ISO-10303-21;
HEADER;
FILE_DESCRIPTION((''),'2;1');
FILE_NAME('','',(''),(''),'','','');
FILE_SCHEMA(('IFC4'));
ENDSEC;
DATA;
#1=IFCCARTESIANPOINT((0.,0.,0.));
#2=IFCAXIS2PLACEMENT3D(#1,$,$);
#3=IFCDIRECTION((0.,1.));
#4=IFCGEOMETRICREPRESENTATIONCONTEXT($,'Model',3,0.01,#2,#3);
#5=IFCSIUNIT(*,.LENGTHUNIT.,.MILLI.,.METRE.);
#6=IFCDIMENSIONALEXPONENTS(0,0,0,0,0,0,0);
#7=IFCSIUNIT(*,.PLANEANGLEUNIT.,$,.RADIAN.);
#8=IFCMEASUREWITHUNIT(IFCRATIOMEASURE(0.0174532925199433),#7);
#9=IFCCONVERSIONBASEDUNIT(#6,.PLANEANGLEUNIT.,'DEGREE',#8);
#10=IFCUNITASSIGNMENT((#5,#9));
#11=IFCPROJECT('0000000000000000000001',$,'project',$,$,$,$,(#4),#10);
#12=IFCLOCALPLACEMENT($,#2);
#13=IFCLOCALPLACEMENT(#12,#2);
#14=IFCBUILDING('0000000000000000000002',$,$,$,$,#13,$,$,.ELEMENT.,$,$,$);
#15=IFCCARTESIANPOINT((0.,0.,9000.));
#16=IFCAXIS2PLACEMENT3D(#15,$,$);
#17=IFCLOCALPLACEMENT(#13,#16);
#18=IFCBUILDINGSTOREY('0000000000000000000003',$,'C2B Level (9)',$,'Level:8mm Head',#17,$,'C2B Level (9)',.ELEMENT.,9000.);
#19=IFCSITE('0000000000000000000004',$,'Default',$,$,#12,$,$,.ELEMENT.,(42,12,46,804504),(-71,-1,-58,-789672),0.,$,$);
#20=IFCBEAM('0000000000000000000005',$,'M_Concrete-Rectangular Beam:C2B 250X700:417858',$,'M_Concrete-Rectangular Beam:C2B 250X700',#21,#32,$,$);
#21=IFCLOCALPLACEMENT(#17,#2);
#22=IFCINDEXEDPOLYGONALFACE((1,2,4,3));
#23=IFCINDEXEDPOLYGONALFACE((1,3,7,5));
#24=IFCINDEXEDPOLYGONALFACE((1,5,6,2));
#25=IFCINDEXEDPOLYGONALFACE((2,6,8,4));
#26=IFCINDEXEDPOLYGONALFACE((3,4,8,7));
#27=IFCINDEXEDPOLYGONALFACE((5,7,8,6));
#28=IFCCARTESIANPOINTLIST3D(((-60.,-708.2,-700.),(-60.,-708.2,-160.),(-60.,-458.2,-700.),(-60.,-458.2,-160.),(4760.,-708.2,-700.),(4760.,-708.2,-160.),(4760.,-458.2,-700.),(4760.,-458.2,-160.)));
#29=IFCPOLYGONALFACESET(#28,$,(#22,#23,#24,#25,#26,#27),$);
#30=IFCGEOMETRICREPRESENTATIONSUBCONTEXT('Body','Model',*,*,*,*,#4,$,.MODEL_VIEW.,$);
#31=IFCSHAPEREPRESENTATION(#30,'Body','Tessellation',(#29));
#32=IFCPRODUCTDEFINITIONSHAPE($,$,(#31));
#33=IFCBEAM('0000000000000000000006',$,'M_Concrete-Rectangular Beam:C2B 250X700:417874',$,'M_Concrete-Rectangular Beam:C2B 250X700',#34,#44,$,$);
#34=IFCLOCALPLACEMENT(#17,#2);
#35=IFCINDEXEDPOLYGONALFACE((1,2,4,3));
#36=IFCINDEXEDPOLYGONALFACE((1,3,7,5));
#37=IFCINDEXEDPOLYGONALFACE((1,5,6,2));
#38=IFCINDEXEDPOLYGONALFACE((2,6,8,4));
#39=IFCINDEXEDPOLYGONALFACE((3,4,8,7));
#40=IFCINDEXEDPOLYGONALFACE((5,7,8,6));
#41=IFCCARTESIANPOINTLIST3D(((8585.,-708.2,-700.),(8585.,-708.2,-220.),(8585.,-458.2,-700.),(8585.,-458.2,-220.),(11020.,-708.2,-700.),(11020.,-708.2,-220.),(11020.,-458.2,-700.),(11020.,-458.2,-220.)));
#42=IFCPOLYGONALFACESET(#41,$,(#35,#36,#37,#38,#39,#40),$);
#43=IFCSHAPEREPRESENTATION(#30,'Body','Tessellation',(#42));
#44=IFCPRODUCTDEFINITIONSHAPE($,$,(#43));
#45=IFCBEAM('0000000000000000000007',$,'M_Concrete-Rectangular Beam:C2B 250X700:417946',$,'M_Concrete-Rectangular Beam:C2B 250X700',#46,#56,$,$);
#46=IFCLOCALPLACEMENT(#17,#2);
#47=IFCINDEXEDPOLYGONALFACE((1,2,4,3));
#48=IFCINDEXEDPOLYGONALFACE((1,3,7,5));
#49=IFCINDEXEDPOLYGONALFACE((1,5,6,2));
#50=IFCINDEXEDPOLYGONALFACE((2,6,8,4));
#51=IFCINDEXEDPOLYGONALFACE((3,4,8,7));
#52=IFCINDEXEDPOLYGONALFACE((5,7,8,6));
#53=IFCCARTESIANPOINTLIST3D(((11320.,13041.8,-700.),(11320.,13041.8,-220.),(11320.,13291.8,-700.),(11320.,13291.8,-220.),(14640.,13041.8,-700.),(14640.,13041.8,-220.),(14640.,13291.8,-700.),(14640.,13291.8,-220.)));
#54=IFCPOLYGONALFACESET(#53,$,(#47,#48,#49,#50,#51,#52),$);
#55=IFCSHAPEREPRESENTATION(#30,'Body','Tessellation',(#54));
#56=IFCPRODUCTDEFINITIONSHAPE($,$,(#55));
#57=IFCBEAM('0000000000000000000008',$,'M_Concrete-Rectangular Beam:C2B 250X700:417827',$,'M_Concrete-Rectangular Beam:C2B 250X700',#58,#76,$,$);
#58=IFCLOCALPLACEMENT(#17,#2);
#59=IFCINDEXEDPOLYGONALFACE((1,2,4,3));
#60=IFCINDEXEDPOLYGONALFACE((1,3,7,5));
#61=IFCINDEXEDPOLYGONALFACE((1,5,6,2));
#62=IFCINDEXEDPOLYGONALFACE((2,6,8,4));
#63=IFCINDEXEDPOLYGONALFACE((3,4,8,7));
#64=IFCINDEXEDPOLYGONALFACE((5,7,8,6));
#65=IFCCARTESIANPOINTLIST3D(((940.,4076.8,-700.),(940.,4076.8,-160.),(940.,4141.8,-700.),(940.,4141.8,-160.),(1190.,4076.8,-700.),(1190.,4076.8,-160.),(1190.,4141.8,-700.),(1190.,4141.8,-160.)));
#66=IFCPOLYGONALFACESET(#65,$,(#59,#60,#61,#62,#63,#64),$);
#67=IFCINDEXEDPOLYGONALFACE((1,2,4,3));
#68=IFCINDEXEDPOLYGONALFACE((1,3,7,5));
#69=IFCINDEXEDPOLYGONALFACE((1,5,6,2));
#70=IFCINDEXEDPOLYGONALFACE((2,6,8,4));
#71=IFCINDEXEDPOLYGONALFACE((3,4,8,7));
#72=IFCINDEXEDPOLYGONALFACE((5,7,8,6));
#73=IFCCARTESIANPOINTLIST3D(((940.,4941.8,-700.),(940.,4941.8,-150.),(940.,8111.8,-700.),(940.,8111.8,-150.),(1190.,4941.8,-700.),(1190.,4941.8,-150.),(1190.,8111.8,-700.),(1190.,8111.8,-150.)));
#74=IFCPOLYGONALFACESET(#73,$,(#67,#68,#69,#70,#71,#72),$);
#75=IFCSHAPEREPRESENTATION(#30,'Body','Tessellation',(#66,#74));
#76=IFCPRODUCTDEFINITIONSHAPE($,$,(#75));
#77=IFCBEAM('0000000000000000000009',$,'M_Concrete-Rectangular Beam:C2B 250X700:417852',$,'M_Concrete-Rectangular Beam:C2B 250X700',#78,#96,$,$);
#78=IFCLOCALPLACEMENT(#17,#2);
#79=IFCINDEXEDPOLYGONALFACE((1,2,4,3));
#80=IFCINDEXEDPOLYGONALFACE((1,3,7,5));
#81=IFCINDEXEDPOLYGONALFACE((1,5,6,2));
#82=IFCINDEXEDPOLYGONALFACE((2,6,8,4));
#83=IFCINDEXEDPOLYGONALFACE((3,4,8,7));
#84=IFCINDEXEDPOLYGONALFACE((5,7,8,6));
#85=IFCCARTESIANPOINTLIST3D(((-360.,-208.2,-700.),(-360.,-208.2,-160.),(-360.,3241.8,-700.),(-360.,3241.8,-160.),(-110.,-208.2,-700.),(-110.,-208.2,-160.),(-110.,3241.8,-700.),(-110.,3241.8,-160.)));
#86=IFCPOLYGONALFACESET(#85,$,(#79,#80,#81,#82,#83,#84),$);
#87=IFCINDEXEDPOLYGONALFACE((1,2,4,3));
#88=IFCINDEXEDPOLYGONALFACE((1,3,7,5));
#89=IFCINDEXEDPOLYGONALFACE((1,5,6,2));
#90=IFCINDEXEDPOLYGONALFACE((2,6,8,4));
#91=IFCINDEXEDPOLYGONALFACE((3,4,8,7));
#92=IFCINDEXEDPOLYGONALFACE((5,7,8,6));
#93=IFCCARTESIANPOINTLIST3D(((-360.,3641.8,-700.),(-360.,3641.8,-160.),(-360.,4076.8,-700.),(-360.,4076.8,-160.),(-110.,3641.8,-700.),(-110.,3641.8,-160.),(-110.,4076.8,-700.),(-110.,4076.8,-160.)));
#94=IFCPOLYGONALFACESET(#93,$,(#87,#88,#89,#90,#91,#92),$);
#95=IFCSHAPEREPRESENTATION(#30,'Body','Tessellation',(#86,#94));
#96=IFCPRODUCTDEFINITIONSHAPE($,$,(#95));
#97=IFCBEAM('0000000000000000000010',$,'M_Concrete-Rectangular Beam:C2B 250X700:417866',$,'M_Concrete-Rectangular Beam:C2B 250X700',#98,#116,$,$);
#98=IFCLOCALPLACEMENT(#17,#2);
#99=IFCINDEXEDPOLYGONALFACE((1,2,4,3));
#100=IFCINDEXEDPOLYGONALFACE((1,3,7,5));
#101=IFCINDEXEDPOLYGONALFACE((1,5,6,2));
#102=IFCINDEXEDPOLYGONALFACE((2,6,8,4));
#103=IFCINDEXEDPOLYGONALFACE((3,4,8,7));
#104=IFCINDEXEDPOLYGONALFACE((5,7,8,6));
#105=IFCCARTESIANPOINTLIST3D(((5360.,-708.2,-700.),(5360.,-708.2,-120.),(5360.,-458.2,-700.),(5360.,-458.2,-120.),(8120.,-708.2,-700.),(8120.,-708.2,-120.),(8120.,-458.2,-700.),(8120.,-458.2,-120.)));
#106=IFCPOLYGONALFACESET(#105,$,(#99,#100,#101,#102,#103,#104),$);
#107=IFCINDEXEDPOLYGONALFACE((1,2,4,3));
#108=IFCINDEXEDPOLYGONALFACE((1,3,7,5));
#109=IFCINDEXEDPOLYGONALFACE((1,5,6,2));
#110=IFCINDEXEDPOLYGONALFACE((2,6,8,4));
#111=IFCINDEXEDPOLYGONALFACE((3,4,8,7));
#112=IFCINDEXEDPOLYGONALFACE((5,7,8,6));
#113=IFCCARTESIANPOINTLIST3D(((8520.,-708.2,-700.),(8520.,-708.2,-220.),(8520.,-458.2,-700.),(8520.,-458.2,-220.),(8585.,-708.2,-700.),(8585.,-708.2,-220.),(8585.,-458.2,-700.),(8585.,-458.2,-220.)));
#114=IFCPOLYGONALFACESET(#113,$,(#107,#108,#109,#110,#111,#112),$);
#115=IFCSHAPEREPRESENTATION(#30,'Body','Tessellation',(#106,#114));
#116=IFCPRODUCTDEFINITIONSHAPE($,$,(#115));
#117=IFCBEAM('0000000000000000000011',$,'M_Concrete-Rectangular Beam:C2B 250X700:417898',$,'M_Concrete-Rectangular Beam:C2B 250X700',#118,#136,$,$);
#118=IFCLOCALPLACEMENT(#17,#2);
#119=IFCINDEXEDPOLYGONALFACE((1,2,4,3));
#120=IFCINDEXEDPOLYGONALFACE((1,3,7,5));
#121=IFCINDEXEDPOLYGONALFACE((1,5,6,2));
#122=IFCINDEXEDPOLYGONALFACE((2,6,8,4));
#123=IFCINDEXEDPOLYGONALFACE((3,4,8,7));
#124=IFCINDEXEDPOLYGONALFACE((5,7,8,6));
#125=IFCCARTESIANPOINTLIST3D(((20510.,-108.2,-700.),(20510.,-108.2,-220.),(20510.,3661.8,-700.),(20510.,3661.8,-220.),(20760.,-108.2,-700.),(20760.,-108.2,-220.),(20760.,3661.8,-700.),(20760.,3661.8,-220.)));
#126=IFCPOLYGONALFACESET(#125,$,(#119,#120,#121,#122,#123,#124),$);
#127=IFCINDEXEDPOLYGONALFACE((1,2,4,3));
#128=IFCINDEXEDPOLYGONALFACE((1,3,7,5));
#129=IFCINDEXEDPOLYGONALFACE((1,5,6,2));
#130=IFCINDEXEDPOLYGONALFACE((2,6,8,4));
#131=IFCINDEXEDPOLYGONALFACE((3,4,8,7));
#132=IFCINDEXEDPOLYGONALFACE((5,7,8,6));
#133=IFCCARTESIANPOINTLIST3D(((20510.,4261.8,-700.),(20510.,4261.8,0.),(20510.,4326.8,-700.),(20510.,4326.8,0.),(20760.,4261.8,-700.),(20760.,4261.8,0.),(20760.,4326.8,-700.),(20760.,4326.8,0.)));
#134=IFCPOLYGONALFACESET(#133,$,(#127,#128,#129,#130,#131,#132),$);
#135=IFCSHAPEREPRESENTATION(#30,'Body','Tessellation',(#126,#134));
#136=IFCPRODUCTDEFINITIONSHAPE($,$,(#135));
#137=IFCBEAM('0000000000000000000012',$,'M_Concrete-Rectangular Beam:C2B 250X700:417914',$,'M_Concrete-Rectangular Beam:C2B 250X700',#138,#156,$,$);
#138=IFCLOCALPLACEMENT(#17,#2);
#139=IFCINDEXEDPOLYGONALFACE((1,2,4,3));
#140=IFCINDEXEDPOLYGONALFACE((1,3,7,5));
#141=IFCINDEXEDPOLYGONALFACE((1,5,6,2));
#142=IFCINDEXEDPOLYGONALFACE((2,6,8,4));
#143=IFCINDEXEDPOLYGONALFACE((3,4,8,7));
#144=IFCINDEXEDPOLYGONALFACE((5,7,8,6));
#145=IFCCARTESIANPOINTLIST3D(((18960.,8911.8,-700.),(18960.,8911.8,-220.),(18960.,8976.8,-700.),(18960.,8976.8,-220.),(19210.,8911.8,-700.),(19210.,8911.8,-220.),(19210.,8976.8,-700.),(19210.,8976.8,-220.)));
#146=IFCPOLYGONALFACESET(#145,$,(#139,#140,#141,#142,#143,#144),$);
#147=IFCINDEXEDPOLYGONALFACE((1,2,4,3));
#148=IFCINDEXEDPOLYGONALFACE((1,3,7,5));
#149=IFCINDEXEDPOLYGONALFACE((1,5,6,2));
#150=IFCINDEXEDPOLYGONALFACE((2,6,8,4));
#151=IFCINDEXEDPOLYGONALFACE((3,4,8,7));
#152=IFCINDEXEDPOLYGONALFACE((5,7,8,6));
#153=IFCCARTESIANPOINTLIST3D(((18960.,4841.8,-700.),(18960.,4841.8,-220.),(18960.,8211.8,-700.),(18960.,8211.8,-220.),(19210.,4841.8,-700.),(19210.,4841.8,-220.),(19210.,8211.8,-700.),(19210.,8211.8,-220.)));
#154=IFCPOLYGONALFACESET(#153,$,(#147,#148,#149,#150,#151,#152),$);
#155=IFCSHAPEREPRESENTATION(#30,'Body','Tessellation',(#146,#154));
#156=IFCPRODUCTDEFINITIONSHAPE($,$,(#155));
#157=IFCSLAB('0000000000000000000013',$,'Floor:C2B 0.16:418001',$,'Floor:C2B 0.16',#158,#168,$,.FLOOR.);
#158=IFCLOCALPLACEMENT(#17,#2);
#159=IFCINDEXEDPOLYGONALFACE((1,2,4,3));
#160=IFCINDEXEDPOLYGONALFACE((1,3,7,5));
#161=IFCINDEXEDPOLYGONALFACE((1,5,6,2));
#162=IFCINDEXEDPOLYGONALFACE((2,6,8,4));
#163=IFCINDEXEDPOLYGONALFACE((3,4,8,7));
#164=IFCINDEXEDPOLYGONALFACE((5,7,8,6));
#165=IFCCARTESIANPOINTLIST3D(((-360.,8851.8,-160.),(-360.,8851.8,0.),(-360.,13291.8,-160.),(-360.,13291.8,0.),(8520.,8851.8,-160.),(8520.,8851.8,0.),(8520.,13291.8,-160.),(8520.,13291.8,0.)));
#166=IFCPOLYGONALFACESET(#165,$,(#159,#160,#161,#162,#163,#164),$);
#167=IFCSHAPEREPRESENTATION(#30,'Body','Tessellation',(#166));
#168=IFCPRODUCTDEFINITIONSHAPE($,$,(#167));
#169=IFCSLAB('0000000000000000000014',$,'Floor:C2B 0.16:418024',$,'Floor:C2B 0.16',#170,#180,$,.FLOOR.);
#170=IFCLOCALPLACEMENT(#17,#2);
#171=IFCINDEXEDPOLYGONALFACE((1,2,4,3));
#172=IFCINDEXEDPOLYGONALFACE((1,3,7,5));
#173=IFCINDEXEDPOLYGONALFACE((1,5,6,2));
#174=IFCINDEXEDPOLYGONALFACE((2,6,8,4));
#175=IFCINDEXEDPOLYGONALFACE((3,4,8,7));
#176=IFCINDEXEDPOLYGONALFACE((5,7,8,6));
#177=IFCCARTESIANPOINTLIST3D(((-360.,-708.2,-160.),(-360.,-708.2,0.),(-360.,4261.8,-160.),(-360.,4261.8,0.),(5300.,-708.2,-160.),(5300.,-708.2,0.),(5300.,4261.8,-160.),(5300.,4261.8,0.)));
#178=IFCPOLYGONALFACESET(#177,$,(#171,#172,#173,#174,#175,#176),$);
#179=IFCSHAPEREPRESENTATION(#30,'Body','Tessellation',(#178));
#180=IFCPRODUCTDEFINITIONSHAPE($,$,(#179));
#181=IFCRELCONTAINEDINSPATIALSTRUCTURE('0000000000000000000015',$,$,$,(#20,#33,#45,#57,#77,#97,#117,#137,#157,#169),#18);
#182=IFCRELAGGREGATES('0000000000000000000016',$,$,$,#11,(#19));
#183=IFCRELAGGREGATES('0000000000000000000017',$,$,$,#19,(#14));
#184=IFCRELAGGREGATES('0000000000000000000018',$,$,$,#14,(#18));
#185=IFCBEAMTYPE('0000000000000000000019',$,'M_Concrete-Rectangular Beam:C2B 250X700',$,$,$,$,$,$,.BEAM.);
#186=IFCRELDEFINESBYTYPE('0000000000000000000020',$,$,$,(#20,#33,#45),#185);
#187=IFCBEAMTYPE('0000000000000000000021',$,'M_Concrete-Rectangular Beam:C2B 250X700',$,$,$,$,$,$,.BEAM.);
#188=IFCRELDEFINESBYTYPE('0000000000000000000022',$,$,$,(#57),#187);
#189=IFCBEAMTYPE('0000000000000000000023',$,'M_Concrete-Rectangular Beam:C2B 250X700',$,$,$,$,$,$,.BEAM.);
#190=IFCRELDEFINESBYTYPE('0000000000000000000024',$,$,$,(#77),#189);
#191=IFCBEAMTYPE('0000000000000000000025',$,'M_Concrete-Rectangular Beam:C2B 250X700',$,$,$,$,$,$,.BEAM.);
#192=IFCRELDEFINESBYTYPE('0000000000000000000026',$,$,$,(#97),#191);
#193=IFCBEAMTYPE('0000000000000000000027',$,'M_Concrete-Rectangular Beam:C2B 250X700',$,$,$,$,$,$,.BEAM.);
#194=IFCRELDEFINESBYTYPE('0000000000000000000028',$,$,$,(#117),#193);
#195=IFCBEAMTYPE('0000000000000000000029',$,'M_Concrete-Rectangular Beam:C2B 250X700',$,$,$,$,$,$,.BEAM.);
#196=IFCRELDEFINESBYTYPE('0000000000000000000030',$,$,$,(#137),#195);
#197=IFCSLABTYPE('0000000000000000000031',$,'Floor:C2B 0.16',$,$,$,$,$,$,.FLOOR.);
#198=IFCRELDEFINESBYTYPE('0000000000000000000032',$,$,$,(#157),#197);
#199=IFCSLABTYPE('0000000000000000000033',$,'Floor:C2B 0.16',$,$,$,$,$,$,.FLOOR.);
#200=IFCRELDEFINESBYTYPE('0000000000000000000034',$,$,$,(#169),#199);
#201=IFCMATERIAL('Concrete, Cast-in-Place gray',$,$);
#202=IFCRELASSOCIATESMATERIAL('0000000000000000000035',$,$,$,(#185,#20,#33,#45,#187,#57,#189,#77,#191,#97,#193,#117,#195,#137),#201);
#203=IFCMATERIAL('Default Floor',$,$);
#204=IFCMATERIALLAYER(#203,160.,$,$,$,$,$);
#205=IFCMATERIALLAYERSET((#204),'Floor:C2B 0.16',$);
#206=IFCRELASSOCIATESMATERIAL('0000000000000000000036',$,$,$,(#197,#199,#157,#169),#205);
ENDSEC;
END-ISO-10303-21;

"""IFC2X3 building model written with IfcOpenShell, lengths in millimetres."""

from ifc_helpers import new_model, entity, si_unit, converted_unit, direction, frame, frame_2d, origin, place, context, subcontext, project, spatial, rectangle, extrude, source, transform, mapped, material, layer, layer_set, layer_usage, type_object, type_shapes, element, save


model = new_model("IFC2X3")

# Units and contexts
model_context = context("Model", 3, precision=0.01, world=origin(), true_north=direction((0.0, 1.0)))
body_context = subcontext(model_context, "Body", "Model", "MODEL_VIEW")
ifc_project = project(units=[si_unit("LENGTHUNIT", "METRE", prefix="MILLI"), converted_unit("PLANEANGLEUNIT", "DEGREE", entity("IfcRatioMeasure", 0.0174532925199433), si_unit("PLANEANGLEUNIT", "RADIAN"), dimensions=[0, 0, 0, 0, 0, 0, 0])], contexts=[model_context])

# Site, building, storey
site_placement = place(None, origin())
site = spatial("IfcSite", under=ifc_project, at=site_placement, Name="Default", CompositionType="ELEMENT", RefLatitude=(42, 12, 46, 804504), RefLongitude=(-71, -1, -58, -789672), RefElevation=0.0)
building_placement = place(site_placement, origin())
building = spatial("IfcBuilding", under=site, at=building_placement, CompositionType="ELEMENT")
storey_placement = place(building_placement, frame((0.0, 0.0, 9000.0)))
storey = spatial("IfcBuildingStorey", under=building, at=storey_placement, Name="C2B Level (9)", ObjectType="Level:8mm Head", LongName="C2B Level (9)", CompositionType="ELEMENT", Elevation=9000.0)

# Beams
ifc_material_1 = material(Name="Concrete, Cast-in-Place gray")
beam_type_1 = type_object("IfcBeamType", Name="M_Concrete-Rectangular Beam:C2B 250X700", PredefinedType="BEAM", material=ifc_material_1)
beam_1_placement = place(storey_placement, frame((4760.0, -583.2, 0.0), z_axis=(0.0, 0.0, 1.0), x_axis=(-1.0, 0.0, 0.0)))
element("IfcBeam", 1, at=beam_1_placement, inside=storey, type_object=beam_type_1, material=ifc_material_1, Name="M_Concrete-Rectangular Beam:C2B 250X700:417858", ObjectType="M_Concrete-Rectangular Beam:C2B 250X700", context=body_context, shape_type="SweptSolid", body=[
    extrude(rectangle(XDim=540.0, YDim=250.0, at=frame_2d((0.0, 0.0), x_axis=(1.0, 0.0))), frame((0.0, 0.0, -430.0), z_axis=(1.0, 0.0, 0.0), x_axis=(0.0, 0.0, -1.0)), (0.0, 0.0, 1.0), 4820.0),
])
beam_2_placement = place(storey_placement, frame((8460.0, -583.2, 0.0)))
element("IfcBeam", 2, at=beam_2_placement, inside=storey, type_object=beam_type_1, material=ifc_material_1, Name="M_Concrete-Rectangular Beam:C2B 250X700:417874", ObjectType="M_Concrete-Rectangular Beam:C2B 250X700", context=body_context, shape_type="SweptSolid", body=[
    extrude(rectangle(XDim=480.0, YDim=250.0, at=frame_2d((0.0, 0.0), x_axis=(1.0, 0.0))), frame((125.0, 0.0, -460.0), z_axis=(1.0, 0.0, 0.0), x_axis=(0.0, 0.0, -1.0)), (0.0, 0.0, 1.0), 2435.0),
])
beam_3_placement = place(storey_placement, frame((14640.0, 13166.8, 0.0), z_axis=(0.0, 0.0, 1.0), x_axis=(-1.0, 0.0, 0.0)))
element("IfcBeam", 3, at=beam_3_placement, inside=storey, type_object=beam_type_1, material=ifc_material_1, Name="M_Concrete-Rectangular Beam:C2B 250X700:417946", ObjectType="M_Concrete-Rectangular Beam:C2B 250X700", context=body_context, shape_type="SweptSolid", body=[
    extrude(rectangle(XDim=480.0, YDim=250.0, at=frame_2d((0.0, 0.0), x_axis=(1.0, 0.0))), frame((0.0, 0.0, -460.0), z_axis=(1.0, 0.0, 0.0), x_axis=(0.0, 0.0, -1.0)), (0.0, 0.0, 1.0), 3320.0),
])
beam_type_2 = type_object("IfcBeamType", Name="M_Concrete-Rectangular Beam:C2B 250X700", PredefinedType="BEAM", material=ifc_material_1)
shared_shape_1 = source(origin(), body_context, "Body", "SweptSolid", [
    extrude(rectangle(XDim=540.0, YDim=250.0, at=frame_2d((0.0, 0.0), x_axis=(0.0, 1.0))), frame((1065.0, 4141.8, 8570.0), z_axis=(0.0, -1.0, 0.0), x_axis=(-1.0, 0.0, 0.0)), (0.0, 0.0, 1.0), 65.0),
    extrude(rectangle(XDim=550.0, YDim=250.0, at=frame_2d((0.0, 0.0), x_axis=(0.0, 1.0))), frame((1065.0, 8111.8, 8575.0), z_axis=(0.0, -1.0, 0.0), x_axis=(-1.0, 0.0, 0.0)), (0.0, 0.0, 1.0), 3170.0),
])
type_shapes(beam_type_2, [shared_shape_1])
beam_4_placement = place(storey_placement, frame((0.0, 0.0, -9000.0)))
element("IfcBeam", 4, at=beam_4_placement, inside=storey, type_object=beam_type_2, material=ifc_material_1, Name="M_Concrete-Rectangular Beam:C2B 250X700:417827", ObjectType="M_Concrete-Rectangular Beam:C2B 250X700", context=body_context, shape_type="MappedRepresentation", body=[
    mapped(shared_shape_1, transform((0.0, 0.0, 0.0), scale=1.0)),
])
beam_type_3 = type_object("IfcBeamType", Name="M_Concrete-Rectangular Beam:C2B 250X700", PredefinedType="BEAM", material=ifc_material_1)
shared_shape_2 = source(origin(), body_context, "Body", "SweptSolid", [
    extrude(rectangle(XDim=540.0, YDim=250.0, at=frame_2d((0.0, 0.0), x_axis=(0.0, 1.0))), frame((-235.0, 3241.8, 8570.0), z_axis=(0.0, -1.0, 0.0), x_axis=(-1.0, 0.0, 0.0)), (0.0, 0.0, 1.0), 3450.0),
    extrude(rectangle(XDim=540.0, YDim=250.0, at=frame_2d((0.0, 0.0), x_axis=(0.0, 1.0))), frame((-235.0, 4076.8, 8570.0), z_axis=(0.0, -1.0, 0.0), x_axis=(-1.0, 0.0, 0.0)), (0.0, 0.0, 1.0), 435.0),
])
type_shapes(beam_type_3, [shared_shape_2])
beam_5_placement = place(storey_placement, frame((0.0, 0.0, -9000.0)))
element("IfcBeam", 5, at=beam_5_placement, inside=storey, type_object=beam_type_3, material=ifc_material_1, Name="M_Concrete-Rectangular Beam:C2B 250X700:417852", ObjectType="M_Concrete-Rectangular Beam:C2B 250X700", context=body_context, shape_type="MappedRepresentation", body=[
    mapped(shared_shape_2, transform((0.0, 0.0, 0.0), scale=1.0)),
])
beam_type_4 = type_object("IfcBeamType", Name="M_Concrete-Rectangular Beam:C2B 250X700", PredefinedType="BEAM", material=ifc_material_1)
shared_shape_3 = source(origin(), body_context, "Body", "SweptSolid", [
    extrude(rectangle(XDim=580.0, YDim=250.0, at=frame_2d((0.0, 0.0), x_axis=(1.0, 0.0))), frame((8120.0, -583.2, 8590.0), z_axis=(-1.0, 0.0, 0.0), x_axis=(0.0, 0.0, -1.0)), (0.0, 0.0, 1.0), 2760.0),
    extrude(rectangle(XDim=480.0, YDim=250.0, at=frame_2d((0.0, 0.0), x_axis=(1.0, 0.0))), frame((8585.0, -583.2, 8540.0), z_axis=(-1.0, 0.0, 0.0), x_axis=(0.0, 0.0, -1.0)), (0.0, 0.0, 1.0), 65.0),
])
type_shapes(beam_type_4, [shared_shape_3])
beam_6_placement = place(storey_placement, frame((0.0, 0.0, -9000.0)))
element("IfcBeam", 6, at=beam_6_placement, inside=storey, type_object=beam_type_4, material=ifc_material_1, Name="M_Concrete-Rectangular Beam:C2B 250X700:417866", ObjectType="M_Concrete-Rectangular Beam:C2B 250X700", context=body_context, shape_type="MappedRepresentation", body=[
    mapped(shared_shape_3, transform((0.0, 0.0, 0.0), scale=1.0)),
])
beam_type_5 = type_object("IfcBeamType", Name="M_Concrete-Rectangular Beam:C2B 250X700", PredefinedType="BEAM", material=ifc_material_1)
shared_shape_4 = source(origin(), body_context, "Body", "SweptSolid", [
    extrude(rectangle(XDim=480.0, YDim=250.0, at=frame_2d((0.0, 0.0), x_axis=(0.0, 1.0))), frame((20635.0, 3661.8, 8540.0), z_axis=(0.0, -1.0, 0.0), x_axis=(-1.0, 0.0, 0.0)), (0.0, 0.0, 1.0), 3770.0),
    extrude(rectangle(XDim=700.0, YDim=250.0, at=frame_2d((0.0, 0.0), x_axis=(0.0, 1.0))), frame((20635.0, 4326.8, 8650.0), z_axis=(0.0, -1.0, 0.0), x_axis=(-1.0, 0.0, 0.0)), (0.0, 0.0, 1.0), 65.0),
])
type_shapes(beam_type_5, [shared_shape_4])
beam_7_placement = place(storey_placement, frame((0.0, 0.0, -9000.0)))
element("IfcBeam", 7, at=beam_7_placement, inside=storey, type_object=beam_type_5, material=ifc_material_1, Name="M_Concrete-Rectangular Beam:C2B 250X700:417898", ObjectType="M_Concrete-Rectangular Beam:C2B 250X700", context=body_context, shape_type="MappedRepresentation", body=[
    mapped(shared_shape_4, transform((0.0, 0.0, 0.0), scale=1.0)),
])
beam_type_6 = type_object("IfcBeamType", Name="M_Concrete-Rectangular Beam:C2B 250X700", PredefinedType="BEAM", material=ifc_material_1)
shared_shape_5 = source(origin(), body_context, "Body", "SweptSolid", [
    extrude(rectangle(XDim=480.0, YDim=250.0, at=frame_2d((0.0, 0.0), x_axis=(0.0, 1.0))), frame((19085.0, 8911.8, 8540.0), z_axis=(0.0, 1.0, 0.0), x_axis=(-1.0, 0.0, 0.0)), (0.0, 0.0, 1.0), 65.0),
    extrude(rectangle(XDim=480.0, YDim=250.0, at=frame_2d((0.0, 0.0), x_axis=(0.0, 1.0))), frame((19085.0, 4841.8, 8540.0), z_axis=(0.0, 1.0, 0.0), x_axis=(-1.0, 0.0, 0.0)), (0.0, 0.0, 1.0), 3370.0),
])
type_shapes(beam_type_6, [shared_shape_5])
beam_8_placement = place(storey_placement, frame((0.0, 0.0, -9000.0)))
element("IfcBeam", 8, at=beam_8_placement, inside=storey, type_object=beam_type_6, material=ifc_material_1, Name="M_Concrete-Rectangular Beam:C2B 250X700:417914", ObjectType="M_Concrete-Rectangular Beam:C2B 250X700", context=body_context, shape_type="MappedRepresentation", body=[
    mapped(shared_shape_5, transform((0.0, 0.0, 0.0), scale=1.0)),
])

# Slabs
ifc_material_2 = material(Name="Default Floor")
ifc_layer_1 = layer(ifc_material_2, 160.0)
ifc_layer_set_1 = layer_set([ifc_layer_1], Name="Floor:C2B 0.16")
ifc_layer_usage_1 = layer_usage(ifc_layer_set_1, "AXIS3", "POSITIVE", 0.0)
slab_type_1 = type_object("IfcSlabType", Name="Floor:C2B 0.16", PredefinedType="FLOOR", material=ifc_layer_set_1)
slab_1_placement = place(storey_placement, origin())
element("IfcSlab", 9, at=slab_1_placement, inside=storey, type_object=slab_type_1, material=ifc_layer_usage_1, Name="Floor:C2B 0.16:418001", ObjectType="Floor:C2B 0.16", PredefinedType="FLOOR", context=body_context, shape_type="SweptSolid", body=[
    extrude(rectangle(XDim=4440.0, YDim=8880.0, at=frame_2d((0.0, 0.0), x_axis=(1.0, 0.0))), frame((4080.0, 11071.8, 0.0), z_axis=(0.0, 0.0, -1.0), x_axis=(0.0, 1.0, 0.0)), (0.0, 0.0, 1.0), 160.0),
])
ifc_layer_usage_2 = layer_usage(ifc_layer_set_1, "AXIS3", "POSITIVE", 0.0)
slab_type_2 = type_object("IfcSlabType", Name="Floor:C2B 0.16", PredefinedType="FLOOR", material=ifc_layer_set_1)
slab_2_placement = place(storey_placement, origin())
element("IfcSlab", 10, at=slab_2_placement, inside=storey, type_object=slab_type_2, material=ifc_layer_usage_2, Name="Floor:C2B 0.16:418024", ObjectType="Floor:C2B 0.16", PredefinedType="FLOOR", context=body_context, shape_type="SweptSolid", body=[
    extrude(rectangle(XDim=4970.0, YDim=5660.0, at=frame_2d((0.0, 0.0), x_axis=(1.0, 0.0))), frame((2470.0, 1776.8, 0.0), z_axis=(0.0, 0.0, -1.0), x_axis=(0.0, 1.0, 0.0)), (0.0, 0.0, 1.0), 160.0),
])

save(model, "model.ifc")
